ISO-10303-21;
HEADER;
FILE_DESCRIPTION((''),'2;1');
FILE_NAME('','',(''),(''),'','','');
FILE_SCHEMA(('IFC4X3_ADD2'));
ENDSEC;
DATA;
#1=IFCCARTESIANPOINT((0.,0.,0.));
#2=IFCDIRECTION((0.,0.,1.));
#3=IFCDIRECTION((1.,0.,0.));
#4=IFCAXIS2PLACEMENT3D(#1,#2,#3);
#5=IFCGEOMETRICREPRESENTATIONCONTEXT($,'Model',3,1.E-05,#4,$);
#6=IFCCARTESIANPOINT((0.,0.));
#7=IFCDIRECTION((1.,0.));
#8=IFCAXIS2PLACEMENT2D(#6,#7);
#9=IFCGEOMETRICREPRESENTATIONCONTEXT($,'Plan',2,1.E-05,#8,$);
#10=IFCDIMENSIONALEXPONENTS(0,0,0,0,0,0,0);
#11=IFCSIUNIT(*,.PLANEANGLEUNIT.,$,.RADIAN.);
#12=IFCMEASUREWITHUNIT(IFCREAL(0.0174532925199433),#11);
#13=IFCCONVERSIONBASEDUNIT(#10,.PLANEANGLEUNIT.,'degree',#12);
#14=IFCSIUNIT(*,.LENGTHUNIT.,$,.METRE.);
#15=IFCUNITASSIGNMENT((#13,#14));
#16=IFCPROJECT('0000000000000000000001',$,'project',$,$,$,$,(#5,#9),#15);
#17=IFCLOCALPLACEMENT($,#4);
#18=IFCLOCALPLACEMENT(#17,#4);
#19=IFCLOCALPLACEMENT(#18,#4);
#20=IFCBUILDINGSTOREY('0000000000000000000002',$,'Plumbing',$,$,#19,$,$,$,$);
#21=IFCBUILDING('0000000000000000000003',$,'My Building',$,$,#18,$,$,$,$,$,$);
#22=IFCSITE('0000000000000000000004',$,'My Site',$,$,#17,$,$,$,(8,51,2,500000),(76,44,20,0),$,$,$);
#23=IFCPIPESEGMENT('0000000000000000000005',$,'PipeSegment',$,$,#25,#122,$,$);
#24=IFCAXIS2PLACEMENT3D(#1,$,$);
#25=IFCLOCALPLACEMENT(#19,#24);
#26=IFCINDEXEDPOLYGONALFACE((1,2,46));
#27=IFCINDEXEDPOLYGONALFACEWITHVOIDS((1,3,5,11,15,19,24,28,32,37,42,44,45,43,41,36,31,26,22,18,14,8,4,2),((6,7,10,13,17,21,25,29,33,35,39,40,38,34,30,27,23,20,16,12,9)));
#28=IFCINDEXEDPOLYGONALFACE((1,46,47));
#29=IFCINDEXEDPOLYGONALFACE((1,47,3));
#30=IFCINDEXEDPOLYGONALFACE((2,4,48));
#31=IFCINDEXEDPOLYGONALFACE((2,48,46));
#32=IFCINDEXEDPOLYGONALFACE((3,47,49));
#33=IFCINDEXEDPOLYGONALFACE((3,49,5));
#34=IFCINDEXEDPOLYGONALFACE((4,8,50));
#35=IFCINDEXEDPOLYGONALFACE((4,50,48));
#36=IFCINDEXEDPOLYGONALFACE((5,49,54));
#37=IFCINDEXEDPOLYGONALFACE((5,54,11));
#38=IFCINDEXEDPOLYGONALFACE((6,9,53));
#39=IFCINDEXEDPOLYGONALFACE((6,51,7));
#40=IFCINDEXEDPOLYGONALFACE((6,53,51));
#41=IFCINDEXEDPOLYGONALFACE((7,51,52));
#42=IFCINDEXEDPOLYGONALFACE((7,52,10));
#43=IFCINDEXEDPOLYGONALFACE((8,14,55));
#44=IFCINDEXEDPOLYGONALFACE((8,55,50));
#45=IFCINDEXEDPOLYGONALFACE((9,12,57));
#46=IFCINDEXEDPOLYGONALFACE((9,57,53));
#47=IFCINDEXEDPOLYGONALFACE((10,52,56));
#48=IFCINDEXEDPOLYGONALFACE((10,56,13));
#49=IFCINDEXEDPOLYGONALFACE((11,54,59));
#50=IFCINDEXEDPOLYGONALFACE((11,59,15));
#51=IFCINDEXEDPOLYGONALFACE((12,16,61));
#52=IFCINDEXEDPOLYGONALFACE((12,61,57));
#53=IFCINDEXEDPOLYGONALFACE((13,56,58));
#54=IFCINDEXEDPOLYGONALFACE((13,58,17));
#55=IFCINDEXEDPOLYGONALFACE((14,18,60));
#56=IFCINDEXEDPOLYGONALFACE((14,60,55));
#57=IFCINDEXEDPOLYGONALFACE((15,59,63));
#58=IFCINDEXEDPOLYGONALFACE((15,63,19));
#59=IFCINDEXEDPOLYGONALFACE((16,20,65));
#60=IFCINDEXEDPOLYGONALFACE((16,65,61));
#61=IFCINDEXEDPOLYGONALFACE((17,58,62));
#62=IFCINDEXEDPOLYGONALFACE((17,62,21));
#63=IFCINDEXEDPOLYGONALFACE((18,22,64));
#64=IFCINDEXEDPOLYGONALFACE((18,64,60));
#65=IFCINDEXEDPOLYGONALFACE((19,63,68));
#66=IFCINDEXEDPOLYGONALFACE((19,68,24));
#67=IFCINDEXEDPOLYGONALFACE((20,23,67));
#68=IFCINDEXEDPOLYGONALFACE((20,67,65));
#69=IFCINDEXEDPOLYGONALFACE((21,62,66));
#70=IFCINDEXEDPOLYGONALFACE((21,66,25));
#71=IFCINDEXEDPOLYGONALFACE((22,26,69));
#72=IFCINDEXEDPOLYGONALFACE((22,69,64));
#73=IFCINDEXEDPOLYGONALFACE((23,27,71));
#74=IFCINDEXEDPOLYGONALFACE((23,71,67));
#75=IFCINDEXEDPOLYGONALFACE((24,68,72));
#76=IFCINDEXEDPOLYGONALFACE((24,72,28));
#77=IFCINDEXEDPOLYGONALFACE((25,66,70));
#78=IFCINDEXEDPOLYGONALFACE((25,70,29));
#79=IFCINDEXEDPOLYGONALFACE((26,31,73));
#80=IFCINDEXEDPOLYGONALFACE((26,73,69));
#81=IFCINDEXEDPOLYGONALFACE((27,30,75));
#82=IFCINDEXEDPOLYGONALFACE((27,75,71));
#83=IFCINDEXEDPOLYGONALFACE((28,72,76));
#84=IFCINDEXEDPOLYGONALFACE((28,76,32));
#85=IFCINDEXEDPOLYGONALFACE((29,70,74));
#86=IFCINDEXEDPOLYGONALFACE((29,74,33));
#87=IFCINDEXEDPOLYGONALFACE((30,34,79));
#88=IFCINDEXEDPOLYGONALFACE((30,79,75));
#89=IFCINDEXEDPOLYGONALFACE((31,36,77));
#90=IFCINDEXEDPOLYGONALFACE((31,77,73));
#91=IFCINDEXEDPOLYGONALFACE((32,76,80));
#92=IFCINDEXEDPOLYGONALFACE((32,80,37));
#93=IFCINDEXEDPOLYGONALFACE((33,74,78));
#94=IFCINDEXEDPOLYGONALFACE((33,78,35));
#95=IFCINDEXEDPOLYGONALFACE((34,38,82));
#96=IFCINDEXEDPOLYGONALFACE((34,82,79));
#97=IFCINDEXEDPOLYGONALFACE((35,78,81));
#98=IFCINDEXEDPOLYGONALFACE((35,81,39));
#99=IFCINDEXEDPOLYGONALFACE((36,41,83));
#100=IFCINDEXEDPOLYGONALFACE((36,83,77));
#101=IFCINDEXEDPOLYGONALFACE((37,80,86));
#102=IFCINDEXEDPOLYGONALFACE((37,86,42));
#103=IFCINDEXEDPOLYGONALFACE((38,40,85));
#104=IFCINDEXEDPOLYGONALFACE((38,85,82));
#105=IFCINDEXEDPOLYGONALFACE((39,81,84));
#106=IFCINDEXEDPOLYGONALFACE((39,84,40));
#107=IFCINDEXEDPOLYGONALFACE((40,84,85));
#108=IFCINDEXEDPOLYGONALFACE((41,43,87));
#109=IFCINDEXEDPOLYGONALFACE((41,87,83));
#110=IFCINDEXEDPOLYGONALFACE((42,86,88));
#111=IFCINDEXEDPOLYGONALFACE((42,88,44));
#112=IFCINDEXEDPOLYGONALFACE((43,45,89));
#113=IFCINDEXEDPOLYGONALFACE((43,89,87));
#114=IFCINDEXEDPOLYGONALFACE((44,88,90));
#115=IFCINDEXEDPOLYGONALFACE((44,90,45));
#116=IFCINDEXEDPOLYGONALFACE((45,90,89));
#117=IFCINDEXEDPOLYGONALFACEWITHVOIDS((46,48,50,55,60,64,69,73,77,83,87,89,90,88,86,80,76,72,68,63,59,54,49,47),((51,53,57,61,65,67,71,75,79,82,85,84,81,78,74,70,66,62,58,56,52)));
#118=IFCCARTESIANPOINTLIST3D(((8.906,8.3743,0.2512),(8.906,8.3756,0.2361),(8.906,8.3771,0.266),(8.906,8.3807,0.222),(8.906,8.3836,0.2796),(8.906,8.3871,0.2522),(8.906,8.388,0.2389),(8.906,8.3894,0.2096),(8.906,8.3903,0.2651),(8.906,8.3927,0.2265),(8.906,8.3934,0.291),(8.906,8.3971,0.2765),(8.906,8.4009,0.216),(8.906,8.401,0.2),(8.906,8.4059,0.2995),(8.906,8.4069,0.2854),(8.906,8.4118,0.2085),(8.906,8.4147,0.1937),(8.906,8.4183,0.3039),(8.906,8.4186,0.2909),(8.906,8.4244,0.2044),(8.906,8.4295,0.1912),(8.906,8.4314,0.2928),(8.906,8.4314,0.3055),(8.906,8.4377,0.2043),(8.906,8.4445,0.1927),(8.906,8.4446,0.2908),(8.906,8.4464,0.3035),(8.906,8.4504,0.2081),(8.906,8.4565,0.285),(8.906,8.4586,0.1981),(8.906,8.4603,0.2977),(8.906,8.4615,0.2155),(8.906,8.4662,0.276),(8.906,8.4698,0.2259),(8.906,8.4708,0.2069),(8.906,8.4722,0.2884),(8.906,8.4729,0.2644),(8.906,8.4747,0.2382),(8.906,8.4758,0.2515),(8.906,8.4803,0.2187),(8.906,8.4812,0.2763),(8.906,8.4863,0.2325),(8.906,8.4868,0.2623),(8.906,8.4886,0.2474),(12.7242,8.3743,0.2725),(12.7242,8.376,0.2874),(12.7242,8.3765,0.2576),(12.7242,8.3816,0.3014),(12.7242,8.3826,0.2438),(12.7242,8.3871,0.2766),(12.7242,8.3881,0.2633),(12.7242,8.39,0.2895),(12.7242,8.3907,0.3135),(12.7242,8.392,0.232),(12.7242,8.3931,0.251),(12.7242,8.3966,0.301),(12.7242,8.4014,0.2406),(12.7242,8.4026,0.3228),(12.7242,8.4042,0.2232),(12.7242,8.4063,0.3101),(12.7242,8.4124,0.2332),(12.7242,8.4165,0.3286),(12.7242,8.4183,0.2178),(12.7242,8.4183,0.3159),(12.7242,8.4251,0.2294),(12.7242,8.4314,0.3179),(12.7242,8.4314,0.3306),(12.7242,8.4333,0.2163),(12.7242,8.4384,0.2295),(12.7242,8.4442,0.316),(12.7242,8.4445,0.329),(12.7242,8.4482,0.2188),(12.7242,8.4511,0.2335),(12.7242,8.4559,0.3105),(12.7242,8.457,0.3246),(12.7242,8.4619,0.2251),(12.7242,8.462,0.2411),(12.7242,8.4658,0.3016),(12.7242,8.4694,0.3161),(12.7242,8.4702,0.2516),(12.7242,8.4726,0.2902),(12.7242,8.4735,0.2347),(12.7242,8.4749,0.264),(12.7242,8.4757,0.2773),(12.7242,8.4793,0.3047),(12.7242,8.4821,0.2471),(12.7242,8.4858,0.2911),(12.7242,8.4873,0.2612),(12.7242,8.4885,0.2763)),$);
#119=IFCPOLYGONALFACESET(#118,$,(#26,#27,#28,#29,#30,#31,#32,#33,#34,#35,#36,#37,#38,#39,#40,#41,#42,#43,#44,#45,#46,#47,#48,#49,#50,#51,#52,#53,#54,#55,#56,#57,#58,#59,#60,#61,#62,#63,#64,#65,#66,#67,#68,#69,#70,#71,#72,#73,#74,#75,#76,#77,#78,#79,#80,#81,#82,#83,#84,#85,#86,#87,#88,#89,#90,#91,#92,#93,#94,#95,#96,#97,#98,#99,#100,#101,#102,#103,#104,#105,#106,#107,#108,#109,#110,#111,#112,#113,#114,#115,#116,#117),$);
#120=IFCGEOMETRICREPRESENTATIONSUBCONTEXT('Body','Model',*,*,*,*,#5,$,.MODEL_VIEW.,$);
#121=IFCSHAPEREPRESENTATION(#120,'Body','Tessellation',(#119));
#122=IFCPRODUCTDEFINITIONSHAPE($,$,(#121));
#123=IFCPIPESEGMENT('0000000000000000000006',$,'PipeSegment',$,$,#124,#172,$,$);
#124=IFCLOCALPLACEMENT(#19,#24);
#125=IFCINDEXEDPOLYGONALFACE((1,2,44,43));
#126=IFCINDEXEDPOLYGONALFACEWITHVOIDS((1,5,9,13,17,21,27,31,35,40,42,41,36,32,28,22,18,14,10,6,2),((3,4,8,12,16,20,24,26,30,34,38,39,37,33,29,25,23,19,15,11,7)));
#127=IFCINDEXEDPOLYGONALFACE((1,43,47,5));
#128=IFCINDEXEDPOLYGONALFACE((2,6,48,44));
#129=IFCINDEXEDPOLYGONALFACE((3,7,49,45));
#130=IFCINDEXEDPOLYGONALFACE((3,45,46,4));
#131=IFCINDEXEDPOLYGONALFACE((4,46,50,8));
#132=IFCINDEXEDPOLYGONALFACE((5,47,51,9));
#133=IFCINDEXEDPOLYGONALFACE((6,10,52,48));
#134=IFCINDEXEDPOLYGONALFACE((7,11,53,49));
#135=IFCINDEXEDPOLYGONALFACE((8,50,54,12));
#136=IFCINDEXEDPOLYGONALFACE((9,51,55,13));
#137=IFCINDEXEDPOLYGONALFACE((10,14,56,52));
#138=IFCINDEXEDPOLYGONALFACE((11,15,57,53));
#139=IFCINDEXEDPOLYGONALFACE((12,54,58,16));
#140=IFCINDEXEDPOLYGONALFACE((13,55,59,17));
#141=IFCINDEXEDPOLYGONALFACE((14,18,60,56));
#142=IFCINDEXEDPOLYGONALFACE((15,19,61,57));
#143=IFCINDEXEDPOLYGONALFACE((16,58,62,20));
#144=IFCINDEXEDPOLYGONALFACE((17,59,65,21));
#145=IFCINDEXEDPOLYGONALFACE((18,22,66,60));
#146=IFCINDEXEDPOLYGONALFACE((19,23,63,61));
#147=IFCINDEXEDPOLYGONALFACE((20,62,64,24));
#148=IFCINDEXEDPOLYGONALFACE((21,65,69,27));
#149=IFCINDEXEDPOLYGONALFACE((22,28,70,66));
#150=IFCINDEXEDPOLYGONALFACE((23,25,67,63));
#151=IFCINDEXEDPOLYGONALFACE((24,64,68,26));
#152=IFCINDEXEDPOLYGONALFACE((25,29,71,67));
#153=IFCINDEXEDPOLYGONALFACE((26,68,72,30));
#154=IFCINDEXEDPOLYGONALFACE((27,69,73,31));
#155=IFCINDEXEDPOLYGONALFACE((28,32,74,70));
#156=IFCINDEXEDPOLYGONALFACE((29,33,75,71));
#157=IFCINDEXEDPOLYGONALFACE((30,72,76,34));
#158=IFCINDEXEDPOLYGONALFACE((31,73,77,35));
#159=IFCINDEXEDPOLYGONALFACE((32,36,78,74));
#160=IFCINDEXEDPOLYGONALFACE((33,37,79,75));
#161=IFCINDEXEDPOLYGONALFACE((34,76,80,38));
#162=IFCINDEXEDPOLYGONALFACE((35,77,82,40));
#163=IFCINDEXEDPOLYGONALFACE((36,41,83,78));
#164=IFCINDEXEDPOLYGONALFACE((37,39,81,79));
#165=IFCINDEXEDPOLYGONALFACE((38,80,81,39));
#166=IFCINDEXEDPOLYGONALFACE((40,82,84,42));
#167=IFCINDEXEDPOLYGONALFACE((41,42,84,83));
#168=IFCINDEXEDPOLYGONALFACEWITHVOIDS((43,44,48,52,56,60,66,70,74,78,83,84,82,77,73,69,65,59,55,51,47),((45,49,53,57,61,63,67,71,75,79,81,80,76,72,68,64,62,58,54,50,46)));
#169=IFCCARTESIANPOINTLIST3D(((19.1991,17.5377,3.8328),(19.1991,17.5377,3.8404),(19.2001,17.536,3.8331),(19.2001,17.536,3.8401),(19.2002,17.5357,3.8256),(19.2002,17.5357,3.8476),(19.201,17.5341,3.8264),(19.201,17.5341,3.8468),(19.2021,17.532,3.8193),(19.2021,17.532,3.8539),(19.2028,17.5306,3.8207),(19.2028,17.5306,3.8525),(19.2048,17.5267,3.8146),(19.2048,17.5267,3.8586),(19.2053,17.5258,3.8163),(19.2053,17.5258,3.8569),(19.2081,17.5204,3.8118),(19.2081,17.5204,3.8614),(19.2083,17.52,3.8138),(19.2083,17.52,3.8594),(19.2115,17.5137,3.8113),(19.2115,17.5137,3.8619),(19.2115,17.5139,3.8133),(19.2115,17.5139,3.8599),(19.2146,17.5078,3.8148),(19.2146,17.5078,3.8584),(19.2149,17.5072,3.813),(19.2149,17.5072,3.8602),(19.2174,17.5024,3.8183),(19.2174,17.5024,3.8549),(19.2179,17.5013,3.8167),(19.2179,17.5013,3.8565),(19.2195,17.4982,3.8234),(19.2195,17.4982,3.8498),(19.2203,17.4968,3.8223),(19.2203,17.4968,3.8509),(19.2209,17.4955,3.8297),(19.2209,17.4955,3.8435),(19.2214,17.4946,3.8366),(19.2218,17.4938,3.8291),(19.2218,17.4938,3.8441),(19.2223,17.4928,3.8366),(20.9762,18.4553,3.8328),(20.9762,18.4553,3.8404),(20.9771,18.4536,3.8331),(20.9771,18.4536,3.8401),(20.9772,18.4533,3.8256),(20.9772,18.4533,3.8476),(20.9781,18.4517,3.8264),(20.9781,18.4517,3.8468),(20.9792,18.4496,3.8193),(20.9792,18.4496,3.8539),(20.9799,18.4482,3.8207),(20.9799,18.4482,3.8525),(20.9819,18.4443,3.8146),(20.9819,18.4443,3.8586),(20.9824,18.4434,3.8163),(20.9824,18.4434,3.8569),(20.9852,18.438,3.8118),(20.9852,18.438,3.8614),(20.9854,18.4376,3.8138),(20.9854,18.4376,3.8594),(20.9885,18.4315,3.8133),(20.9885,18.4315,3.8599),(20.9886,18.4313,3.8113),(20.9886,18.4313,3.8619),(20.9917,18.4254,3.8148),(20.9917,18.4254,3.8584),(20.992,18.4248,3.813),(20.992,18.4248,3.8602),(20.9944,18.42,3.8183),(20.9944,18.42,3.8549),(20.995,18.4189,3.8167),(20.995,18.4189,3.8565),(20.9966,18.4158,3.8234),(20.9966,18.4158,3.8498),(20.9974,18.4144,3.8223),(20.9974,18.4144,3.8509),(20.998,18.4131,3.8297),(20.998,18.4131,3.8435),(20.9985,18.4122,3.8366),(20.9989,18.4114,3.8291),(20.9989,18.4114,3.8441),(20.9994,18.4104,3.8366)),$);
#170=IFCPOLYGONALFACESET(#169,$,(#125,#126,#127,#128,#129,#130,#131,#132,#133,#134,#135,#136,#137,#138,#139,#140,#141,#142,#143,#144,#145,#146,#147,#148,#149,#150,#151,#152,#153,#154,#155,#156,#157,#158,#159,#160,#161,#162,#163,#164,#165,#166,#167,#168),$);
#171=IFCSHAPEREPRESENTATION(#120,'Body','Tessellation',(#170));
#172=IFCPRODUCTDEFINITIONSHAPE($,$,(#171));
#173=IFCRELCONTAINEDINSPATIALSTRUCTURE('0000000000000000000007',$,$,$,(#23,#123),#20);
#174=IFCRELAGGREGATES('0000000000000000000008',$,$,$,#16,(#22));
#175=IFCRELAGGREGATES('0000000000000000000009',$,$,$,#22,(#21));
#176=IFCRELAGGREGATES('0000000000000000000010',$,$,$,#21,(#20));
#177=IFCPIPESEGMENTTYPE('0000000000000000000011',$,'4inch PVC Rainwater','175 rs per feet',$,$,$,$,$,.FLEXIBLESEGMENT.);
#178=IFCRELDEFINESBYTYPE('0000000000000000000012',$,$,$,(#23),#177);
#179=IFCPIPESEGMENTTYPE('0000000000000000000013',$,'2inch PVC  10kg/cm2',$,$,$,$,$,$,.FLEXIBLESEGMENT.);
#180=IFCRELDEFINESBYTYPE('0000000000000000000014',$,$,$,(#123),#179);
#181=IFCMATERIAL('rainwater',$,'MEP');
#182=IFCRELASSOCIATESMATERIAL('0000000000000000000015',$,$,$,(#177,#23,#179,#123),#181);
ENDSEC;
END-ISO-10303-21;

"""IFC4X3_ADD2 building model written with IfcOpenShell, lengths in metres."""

from ifc_helpers import new_model, entity, si_unit, converted_unit, frame, origin_with_axes, origin_2d_with_axis, place, context, subcontext, project, spatial, hollow_circle, extrude, clip, halfspace, material, material_profile, profile_set, profile_usage, type_object, element, save


model = new_model("IFC4X3_ADD2")

# Units and contexts
model_context = context("Model", 3, precision=1e-05, world=origin_with_axes())
plan_context = context("Plan", 2, precision=1e-05, world=origin_2d_with_axis())
body_context = subcontext(model_context, "Body", "Model", "MODEL_VIEW")
ifc_project = project(units=[converted_unit("PLANEANGLEUNIT", "degree", entity("IfcReal", 0.0174532925199433), si_unit("PLANEANGLEUNIT", "RADIAN"), dimensions=[0, 0, 0, 0, 0, 0, 0]), si_unit("LENGTHUNIT", "METRE")], contexts=[model_context, plan_context])

# Site, building, storey
site_placement = place(None, origin_with_axes())
site = spatial("IfcSite", under=ifc_project, at=site_placement, Name="My Site", RefLatitude=(8, 51, 2, 500000), RefLongitude=(76, 44, 20, 0))
building_placement = place(site_placement, origin_with_axes())
building = spatial("IfcBuilding", under=site, at=building_placement, Name="My Building")
storey_placement = place(building_placement, origin_with_axes())
storey = spatial("IfcBuildingStorey", under=building, at=storey_placement, Name="Plumbing")

# Pipe segments
ifc_material_1 = material(Name="rainwater", Category="MEP")
ifc_material_profile_1 = material_profile(ifc_material_1, hollow_circle(Radius=0.0571, WallThickness=0.0127))
ifc_profile_set_1 = profile_set([ifc_material_profile_1], Name="rainwater")
pipe_segment_type_1 = type_object("IfcPipeSegmentType", Name="4inch PVC Rainwater", Description="175 rs per feet", PredefinedType="FLEXIBLESEGMENT", material=ifc_profile_set_1)
ifc_profile_usage_1 = profile_usage(ifc_profile_set_1)
pipe_segment_1_placement = place(storey_placement, frame((8.7917, 8.4314, 0.2476), z_axis=(0.999978, 0.000001, 0.006573), x_axis=(-0.006573, -0.000001, 0.999978)))
element("IfcPipeSegment", 1, at=pipe_segment_1_placement, inside=storey, type_object=pipe_segment_type_1, material=ifc_profile_usage_1, Name="PipeSegment", context=body_context, shape_type="Clipping", body=[
    clip(clip(extrude(hollow_circle(Radius=0.0571, WallThickness=0.0127), origin_with_axes(), (0.0, 0.0, 1.0), 4.0468), halfspace(frame((-0.0159, -0.1712, 3.9324), z_axis=(-0.006573, -0.000011, 0.999979), x_axis=(-0.999978, 0.0, -0.006573)), False)), halfspace(frame((0.0092, -0.1714, 0.1144), z_axis=(0.006573, 0.000011, -0.999979), x_axis=(0.999978, 0.0, 0.006573)), False)),
])
ifc_material_profile_2 = material_profile(ifc_material_1, hollow_circle(Radius=0.0254, WallThickness=0.002))
ifc_profile_set_2 = profile_set([ifc_material_profile_2], Name="water")
ifc_profile_usage_2 = profile_usage(ifc_profile_set_2)
pipe_segment_type_2 = type_object("IfcPipeSegmentType", Name="2inch PVC  10kg/cm2", PredefinedType="FLEXIBLESEGMENT", material=ifc_profile_set_2)
pipe_segment_2_placement = place(storey_placement, frame((20.9877, 18.433, 3.8366), z_axis=(-0.888539, -0.4588, 0.0), x_axis=(0.4588, -0.888539, 0.0)))
element("IfcPipeSegment", 2, at=pipe_segment_2_placement, inside=storey, type_object=pipe_segment_type_2, material=ifc_profile_usage_2, Name="PipeSegment", context=body_context, shape_type="SweptSolid", body=[
    extrude(hollow_circle(Radius=0.0254, WallThickness=0.002), origin_with_axes(), (0.0, 0.0, 1.0), 2.0),
])

save(model, "model.ifc")
